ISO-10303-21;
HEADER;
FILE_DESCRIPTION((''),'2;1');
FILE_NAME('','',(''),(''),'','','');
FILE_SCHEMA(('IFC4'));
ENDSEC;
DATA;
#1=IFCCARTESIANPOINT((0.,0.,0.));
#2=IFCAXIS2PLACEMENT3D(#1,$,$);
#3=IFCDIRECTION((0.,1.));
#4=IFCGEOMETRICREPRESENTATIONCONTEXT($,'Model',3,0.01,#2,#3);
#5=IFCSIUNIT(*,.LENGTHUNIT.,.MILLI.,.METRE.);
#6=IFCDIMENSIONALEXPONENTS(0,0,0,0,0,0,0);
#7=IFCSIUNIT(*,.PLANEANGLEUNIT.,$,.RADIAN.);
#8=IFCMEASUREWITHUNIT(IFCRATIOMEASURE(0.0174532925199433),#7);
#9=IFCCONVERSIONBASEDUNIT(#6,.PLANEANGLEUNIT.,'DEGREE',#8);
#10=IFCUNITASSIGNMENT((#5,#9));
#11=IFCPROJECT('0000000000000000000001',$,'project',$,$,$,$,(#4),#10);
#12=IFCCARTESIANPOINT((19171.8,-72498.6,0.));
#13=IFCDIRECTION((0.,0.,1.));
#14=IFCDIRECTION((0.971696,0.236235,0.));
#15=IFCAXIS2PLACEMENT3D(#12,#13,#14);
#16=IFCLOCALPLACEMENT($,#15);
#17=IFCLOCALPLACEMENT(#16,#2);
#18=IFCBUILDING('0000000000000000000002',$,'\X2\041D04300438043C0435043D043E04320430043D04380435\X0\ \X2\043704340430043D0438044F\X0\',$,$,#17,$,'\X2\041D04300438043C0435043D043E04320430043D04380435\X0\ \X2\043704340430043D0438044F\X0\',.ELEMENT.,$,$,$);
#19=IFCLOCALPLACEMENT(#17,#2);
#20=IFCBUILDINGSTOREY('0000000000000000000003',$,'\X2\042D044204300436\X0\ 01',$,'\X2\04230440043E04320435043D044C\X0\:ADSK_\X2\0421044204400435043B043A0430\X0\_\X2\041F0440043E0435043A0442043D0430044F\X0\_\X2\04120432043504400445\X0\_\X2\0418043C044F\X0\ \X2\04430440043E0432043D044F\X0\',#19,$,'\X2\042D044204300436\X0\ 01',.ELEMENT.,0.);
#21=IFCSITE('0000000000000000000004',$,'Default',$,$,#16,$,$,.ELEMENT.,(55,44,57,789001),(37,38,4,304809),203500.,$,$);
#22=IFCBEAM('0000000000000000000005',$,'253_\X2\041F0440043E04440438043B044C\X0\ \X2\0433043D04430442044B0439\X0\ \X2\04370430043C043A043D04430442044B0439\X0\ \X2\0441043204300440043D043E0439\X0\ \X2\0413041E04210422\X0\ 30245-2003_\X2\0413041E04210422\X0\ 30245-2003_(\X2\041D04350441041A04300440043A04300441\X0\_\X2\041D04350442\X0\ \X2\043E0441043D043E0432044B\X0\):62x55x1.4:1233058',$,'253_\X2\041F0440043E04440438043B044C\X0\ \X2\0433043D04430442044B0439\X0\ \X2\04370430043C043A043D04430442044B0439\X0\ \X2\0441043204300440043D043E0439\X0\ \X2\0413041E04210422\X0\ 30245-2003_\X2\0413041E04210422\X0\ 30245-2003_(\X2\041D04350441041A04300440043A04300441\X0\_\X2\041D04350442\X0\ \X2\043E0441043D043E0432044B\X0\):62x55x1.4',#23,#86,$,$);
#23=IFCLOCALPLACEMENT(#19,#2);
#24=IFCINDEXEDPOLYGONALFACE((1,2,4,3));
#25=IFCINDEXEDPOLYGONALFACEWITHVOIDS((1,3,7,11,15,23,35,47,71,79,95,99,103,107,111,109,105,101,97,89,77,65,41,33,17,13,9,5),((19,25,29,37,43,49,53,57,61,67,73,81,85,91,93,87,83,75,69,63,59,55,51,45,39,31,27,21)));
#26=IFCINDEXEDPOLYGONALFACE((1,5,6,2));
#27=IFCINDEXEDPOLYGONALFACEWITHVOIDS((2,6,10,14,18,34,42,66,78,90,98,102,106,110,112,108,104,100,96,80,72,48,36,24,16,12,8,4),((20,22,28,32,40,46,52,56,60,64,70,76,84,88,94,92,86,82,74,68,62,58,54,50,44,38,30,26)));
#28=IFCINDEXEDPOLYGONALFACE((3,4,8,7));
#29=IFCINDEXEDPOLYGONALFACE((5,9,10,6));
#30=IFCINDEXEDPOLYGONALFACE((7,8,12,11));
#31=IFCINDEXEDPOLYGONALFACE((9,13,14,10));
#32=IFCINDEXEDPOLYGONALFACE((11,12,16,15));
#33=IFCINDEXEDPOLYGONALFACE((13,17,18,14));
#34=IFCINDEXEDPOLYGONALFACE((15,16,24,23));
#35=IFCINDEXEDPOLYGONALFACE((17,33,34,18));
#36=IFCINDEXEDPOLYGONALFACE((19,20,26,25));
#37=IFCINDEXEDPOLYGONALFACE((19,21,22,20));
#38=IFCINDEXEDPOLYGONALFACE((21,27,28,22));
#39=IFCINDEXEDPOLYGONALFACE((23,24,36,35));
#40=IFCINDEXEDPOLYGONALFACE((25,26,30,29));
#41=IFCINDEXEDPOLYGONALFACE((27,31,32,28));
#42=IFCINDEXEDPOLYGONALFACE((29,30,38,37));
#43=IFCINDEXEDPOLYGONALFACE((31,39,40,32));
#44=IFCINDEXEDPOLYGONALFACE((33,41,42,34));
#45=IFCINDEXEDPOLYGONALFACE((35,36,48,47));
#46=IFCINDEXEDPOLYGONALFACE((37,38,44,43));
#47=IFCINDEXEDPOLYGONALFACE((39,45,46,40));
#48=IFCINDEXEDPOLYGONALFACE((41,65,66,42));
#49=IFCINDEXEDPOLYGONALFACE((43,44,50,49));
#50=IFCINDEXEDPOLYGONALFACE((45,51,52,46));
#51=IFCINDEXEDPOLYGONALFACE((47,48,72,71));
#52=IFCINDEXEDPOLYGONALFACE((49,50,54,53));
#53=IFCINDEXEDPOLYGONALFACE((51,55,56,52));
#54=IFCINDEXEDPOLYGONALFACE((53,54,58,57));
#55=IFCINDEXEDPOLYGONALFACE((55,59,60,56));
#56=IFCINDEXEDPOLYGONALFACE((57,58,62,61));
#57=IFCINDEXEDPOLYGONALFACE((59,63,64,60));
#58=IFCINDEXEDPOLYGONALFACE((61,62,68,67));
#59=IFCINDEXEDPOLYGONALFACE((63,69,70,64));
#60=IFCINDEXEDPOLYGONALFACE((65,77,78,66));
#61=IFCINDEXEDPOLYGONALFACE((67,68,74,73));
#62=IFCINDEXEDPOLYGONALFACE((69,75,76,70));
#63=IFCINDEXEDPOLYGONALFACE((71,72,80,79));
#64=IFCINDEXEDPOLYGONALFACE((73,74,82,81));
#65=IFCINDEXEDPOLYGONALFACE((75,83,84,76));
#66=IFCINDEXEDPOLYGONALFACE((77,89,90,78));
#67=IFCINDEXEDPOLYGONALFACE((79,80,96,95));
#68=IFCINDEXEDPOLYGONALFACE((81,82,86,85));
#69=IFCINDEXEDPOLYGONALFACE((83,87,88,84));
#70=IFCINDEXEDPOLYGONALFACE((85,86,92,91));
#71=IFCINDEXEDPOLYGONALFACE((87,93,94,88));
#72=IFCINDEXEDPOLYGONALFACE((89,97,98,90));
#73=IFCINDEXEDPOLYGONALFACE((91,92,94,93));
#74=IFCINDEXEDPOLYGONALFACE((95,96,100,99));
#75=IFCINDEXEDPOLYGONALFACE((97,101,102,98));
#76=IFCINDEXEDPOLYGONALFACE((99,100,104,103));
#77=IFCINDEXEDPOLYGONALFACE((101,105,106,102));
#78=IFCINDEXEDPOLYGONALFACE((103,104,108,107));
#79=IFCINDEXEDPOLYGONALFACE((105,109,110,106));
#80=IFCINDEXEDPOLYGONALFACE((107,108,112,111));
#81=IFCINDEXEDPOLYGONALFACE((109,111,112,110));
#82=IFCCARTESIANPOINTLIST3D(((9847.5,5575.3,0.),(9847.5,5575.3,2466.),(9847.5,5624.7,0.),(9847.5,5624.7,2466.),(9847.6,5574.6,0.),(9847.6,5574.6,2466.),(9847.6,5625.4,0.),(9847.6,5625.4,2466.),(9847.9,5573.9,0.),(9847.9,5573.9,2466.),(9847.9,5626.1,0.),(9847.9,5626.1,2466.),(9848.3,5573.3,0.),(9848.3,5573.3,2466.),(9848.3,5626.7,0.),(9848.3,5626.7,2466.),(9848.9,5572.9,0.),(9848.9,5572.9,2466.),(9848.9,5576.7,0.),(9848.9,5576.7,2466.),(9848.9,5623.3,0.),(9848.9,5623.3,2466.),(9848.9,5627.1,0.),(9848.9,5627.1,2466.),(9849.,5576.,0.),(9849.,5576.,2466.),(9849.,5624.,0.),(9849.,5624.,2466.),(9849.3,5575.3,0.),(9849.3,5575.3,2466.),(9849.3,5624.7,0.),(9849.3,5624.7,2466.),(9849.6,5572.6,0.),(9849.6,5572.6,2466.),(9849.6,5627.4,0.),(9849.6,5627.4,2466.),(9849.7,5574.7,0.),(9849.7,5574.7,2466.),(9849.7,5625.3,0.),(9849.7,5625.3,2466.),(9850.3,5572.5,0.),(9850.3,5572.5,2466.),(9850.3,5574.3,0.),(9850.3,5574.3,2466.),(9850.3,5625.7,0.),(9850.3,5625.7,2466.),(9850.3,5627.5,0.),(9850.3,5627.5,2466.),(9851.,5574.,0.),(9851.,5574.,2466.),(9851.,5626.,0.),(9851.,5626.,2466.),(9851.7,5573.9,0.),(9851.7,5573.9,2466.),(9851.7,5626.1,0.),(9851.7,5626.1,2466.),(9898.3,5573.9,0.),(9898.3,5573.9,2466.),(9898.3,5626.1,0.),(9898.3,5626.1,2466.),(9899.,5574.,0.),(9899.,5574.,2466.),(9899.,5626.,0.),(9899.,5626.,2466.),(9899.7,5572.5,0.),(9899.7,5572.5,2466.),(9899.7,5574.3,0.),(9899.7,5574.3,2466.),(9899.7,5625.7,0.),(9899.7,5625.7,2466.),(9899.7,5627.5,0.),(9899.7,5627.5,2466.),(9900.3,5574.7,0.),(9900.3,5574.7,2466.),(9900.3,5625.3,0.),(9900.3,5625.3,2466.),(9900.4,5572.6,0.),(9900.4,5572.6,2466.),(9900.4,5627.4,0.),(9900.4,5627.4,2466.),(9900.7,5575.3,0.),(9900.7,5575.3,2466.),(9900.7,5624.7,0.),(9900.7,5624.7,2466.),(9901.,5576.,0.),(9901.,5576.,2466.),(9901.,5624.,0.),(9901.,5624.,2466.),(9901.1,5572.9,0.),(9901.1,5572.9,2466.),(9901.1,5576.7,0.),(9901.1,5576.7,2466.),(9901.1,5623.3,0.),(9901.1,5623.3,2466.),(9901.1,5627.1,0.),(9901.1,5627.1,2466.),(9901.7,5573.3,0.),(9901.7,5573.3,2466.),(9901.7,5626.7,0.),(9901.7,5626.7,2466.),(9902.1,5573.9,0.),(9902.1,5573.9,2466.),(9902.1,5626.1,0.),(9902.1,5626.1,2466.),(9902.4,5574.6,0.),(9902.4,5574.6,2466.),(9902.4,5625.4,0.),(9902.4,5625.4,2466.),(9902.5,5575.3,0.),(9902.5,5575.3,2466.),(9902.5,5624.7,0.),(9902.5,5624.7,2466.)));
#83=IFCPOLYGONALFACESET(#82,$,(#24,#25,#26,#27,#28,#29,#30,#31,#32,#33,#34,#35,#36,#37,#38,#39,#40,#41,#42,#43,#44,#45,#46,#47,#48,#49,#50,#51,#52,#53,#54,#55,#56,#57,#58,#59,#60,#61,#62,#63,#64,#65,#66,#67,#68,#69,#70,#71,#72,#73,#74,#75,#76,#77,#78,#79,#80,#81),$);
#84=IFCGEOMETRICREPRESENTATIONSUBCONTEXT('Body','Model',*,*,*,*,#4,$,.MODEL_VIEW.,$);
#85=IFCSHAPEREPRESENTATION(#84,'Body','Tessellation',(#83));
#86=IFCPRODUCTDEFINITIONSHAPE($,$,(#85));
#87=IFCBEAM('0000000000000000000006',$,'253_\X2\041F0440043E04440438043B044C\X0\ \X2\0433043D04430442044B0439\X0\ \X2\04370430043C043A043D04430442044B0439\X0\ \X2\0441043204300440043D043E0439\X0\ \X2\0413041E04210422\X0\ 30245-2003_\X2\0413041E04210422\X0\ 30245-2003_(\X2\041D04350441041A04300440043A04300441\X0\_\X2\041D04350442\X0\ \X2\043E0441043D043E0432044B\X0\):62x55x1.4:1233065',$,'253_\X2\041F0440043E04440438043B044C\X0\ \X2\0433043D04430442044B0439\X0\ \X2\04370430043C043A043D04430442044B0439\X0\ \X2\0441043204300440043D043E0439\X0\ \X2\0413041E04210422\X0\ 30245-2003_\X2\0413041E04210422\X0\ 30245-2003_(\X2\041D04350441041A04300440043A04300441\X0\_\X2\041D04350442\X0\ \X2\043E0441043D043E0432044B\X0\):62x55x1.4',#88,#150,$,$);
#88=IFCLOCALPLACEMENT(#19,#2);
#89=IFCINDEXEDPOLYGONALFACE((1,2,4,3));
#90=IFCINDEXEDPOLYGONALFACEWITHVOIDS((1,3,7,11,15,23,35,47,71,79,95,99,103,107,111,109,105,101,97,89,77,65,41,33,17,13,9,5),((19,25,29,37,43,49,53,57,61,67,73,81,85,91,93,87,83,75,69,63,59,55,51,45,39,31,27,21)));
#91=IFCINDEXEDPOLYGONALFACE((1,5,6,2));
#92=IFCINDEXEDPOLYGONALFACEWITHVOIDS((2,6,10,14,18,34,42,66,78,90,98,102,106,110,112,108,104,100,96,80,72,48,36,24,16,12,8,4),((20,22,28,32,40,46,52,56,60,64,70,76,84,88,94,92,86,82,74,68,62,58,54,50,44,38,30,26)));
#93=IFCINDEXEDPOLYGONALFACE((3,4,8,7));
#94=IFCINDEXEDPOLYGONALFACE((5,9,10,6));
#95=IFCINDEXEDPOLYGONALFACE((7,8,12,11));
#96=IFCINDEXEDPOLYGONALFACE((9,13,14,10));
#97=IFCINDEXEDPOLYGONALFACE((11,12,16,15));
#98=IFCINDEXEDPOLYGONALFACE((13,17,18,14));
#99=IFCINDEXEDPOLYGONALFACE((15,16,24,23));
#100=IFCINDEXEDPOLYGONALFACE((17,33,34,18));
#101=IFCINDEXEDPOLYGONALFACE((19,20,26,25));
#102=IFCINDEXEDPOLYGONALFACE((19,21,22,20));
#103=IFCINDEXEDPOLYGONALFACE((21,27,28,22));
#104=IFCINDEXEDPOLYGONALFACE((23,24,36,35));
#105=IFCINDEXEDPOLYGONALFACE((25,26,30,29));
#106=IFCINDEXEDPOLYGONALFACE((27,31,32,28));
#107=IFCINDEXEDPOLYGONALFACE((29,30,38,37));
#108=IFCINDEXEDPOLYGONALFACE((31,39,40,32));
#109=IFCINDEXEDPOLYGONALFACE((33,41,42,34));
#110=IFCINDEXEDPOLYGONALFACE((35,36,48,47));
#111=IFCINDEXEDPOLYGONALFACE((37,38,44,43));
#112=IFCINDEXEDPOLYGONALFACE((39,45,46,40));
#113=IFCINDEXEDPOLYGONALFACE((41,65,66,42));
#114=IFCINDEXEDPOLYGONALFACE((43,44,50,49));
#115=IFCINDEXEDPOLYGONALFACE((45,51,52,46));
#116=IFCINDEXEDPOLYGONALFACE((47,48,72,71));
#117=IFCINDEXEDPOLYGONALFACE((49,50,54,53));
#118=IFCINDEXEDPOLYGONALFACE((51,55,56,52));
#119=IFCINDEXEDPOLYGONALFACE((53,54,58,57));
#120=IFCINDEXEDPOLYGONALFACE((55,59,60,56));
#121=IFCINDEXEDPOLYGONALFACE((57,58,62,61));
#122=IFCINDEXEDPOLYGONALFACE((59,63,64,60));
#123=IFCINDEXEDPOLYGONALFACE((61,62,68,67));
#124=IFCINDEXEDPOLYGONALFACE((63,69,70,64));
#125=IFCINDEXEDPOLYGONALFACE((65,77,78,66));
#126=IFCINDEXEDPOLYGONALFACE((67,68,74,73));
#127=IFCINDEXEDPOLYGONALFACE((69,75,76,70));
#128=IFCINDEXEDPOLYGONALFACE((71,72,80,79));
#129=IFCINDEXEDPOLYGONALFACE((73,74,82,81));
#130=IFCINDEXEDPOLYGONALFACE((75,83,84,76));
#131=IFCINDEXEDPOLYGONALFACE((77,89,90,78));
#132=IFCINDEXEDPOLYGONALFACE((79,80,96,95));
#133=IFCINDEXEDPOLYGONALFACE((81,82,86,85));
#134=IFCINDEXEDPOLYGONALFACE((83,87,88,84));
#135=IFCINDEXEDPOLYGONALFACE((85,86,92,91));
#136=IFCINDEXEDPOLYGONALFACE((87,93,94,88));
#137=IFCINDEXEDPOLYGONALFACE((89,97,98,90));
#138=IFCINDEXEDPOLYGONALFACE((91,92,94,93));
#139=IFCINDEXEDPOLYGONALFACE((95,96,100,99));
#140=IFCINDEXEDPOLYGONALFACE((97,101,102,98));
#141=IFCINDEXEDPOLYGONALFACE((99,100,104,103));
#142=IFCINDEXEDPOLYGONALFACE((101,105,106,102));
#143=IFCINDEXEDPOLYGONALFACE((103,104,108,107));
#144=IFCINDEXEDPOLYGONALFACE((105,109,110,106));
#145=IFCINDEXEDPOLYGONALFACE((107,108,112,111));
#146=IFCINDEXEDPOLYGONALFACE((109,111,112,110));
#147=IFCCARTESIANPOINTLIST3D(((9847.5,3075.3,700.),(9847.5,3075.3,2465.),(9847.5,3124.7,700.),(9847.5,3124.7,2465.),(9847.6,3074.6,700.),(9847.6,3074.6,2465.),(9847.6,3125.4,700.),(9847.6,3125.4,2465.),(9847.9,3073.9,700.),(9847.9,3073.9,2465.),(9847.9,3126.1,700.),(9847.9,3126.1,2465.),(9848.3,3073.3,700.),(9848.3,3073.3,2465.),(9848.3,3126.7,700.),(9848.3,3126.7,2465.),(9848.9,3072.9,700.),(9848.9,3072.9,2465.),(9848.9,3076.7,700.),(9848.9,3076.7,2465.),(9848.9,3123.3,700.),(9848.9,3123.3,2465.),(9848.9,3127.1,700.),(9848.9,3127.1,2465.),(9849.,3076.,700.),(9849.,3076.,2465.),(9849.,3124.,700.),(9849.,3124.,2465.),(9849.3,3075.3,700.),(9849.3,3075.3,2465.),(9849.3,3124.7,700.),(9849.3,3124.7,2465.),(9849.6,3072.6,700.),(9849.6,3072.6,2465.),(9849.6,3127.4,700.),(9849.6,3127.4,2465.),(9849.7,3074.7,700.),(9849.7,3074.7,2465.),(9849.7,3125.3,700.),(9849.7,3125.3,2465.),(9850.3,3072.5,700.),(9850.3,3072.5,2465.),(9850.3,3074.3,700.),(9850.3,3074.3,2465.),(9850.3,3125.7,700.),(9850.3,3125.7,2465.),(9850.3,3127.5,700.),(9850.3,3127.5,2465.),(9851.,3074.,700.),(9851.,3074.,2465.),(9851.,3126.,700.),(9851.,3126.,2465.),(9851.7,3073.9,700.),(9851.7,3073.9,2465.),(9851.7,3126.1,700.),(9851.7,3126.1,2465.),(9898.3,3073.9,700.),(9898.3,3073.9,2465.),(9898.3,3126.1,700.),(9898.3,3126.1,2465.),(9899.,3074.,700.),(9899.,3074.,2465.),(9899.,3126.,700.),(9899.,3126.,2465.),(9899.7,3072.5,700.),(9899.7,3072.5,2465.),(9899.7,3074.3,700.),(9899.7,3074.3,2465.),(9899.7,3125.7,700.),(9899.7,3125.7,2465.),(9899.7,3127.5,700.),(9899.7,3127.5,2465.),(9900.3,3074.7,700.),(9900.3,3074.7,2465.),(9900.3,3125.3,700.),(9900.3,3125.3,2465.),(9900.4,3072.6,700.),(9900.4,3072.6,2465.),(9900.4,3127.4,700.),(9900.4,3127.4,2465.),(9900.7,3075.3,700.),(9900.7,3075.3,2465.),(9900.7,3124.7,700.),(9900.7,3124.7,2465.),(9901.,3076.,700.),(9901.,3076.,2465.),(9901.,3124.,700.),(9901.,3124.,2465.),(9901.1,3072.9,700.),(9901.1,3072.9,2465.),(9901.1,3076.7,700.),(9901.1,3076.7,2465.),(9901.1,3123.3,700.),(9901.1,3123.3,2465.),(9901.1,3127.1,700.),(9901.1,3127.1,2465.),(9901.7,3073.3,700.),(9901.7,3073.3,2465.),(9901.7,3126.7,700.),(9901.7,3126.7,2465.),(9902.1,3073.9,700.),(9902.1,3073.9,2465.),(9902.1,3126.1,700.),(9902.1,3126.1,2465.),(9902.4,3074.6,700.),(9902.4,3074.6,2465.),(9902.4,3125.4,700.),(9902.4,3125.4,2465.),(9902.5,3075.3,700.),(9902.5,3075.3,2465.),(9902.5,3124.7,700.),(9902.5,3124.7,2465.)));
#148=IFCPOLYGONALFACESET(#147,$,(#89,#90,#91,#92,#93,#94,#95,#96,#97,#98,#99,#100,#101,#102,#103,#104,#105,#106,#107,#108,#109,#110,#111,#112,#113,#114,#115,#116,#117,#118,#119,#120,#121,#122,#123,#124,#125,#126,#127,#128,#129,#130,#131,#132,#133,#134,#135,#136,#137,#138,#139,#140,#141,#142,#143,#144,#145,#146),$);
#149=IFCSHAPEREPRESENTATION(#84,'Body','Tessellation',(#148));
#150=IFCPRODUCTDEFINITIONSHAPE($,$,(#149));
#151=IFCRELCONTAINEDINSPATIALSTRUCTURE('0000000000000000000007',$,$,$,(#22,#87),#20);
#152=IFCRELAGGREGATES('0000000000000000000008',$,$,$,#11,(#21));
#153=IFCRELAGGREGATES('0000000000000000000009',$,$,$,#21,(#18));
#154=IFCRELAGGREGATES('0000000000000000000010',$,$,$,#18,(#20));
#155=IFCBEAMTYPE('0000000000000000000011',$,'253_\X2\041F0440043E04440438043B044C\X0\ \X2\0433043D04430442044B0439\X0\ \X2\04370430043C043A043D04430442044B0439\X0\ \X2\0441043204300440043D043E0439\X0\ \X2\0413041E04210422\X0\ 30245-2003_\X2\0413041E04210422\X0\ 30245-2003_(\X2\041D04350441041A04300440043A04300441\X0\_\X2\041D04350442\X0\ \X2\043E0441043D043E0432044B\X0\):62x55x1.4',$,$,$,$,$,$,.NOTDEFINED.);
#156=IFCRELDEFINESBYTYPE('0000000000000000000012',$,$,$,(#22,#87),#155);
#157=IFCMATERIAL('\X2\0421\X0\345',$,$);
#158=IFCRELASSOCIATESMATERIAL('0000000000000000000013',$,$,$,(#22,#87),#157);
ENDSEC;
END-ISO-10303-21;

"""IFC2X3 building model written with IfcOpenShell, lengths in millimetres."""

from ifc_helpers import new_model, entity, si_unit, converted_unit, direction, frame, frame_2d, origin, place, context, subcontext, project, spatial, polyline, circle_curve, parameter, trimmed, segment, composite_curve, outline, extrude, material, type_object, element, save


model = new_model("IFC2X3")

# Units and contexts
model_context = context("Model", 3, precision=0.01, world=origin(), true_north=direction((0.0, 1.0)))
body_context = subcontext(model_context, "Body", "Model", "MODEL_VIEW")
ifc_project = project(units=[si_unit("LENGTHUNIT", "METRE", prefix="MILLI"), converted_unit("PLANEANGLEUNIT", "DEGREE", entity("IfcRatioMeasure", 0.0174532925199433), si_unit("PLANEANGLEUNIT", "RADIAN"), dimensions=[0, 0, 0, 0, 0, 0, 0])], contexts=[model_context])

# Site, building, storey
site_placement = place(None, frame((19171.8, -72498.6, 0.0), z_axis=(0.0, 0.0, 1.0), x_axis=(0.971696, 0.236235, 0.0)))
site = spatial("IfcSite", under=ifc_project, at=site_placement, Name="Default", CompositionType="ELEMENT", RefLatitude=(55, 44, 57, 789001), RefLongitude=(37, 38, 4, 304809), RefElevation=203500.0)
building_placement = place(site_placement, origin())
building = spatial("IfcBuilding", under=site, at=building_placement, Name="Наименование здания", LongName="Наименование здания", CompositionType="ELEMENT")
storey_placement = place(building_placement, origin())
storey = spatial("IfcBuildingStorey", under=building, at=storey_placement, Name="Этаж 01", ObjectType="Уровень:ADSK_Стрелка_Проектная_Вверх_Имя уровня", LongName="Этаж 01", CompositionType="ELEMENT", Elevation=0.0)

# Beams
ifc_material_1 = material(Name="С345")
beam_type_1 = type_object("IfcBeamType", Name="253_Профиль гнутый замкнутый сварной ГОСТ 30245-2003_ГОСТ 30245-2003_(НесКаркас_Нет основы):62x55x1.4", PredefinedType="NOTDEFINED")
beam_1_placement = place(storey_placement, frame((9845.9, 5570.9, 0.0), z_axis=(1.0, 0.0, 0.0), x_axis=(0.0, 0.0, -1.0)))
element("IfcBeam", 1, at=beam_1_placement, inside=storey, type_object=beam_type_1, material=ifc_material_1, Name="253_Профиль гнутый замкнутый сварной ГОСТ 30245-2003_ГОСТ 30245-2003_(НесКаркас_Нет основы):62x55x1.4:1233058", ObjectType="253_Профиль гнутый замкнутый сварной ГОСТ 30245-2003_ГОСТ 30245-2003_(НесКаркас_Нет основы):62x55x1.4", context=body_context, shape_type="SweptSolid", body=[
    extrude(outline(composite_curve([segment(trimmed(circle_curve(frame_2d((24.7, -24.7), x_axis=(1.0, 0.0)), 2.8), [parameter(270.0)], [parameter(0.0)], True, "PARAMETER"), True, "CONTINUOUS"), segment(polyline([(27.5, -24.7), (27.5, 24.7)]), True, "CONTINUOUS"), segment(trimmed(circle_curve(frame_2d((24.7, 24.7), x_axis=(1.0, 0.0)), 2.8), [parameter(0.0)], [parameter(90.0)], True, "PARAMETER"), True, "CONTINUOUS"), segment(polyline([(24.7, 27.5), (-24.7, 27.5)]), True, "CONTINUOUS"), segment(trimmed(circle_curve(frame_2d((-24.7, 24.7), x_axis=(1.0, 0.0)), 2.8), [parameter(90.0)], [parameter(180.0)], True, "PARAMETER"), True, "CONTINUOUS"), segment(polyline([(-27.5, 24.7), (-27.5, -24.7)]), True, "CONTINUOUS"), segment(trimmed(circle_curve(frame_2d((-24.7, -24.7), x_axis=(1.0, 0.0)), 2.8), [parameter(180.0)], [parameter(270.0)], True, "PARAMETER"), True, "CONTINUOUS"), segment(polyline([(-24.7, -27.5), (24.7, -27.5)]), True, "CONTINUOUS")], self_intersect=False), holes=[composite_curve([segment(polyline([(23.3, -26.1), (-23.3, -26.1)]), True, "CONTINUOUS"), segment(trimmed(circle_curve(frame_2d((-23.3, -23.3), x_axis=(1.0, 0.0)), 2.8), [parameter(180.0)], [parameter(270.0)], True, "PARAMETER"), False, "CONTINUOUS"), segment(polyline([(-26.1, -23.3), (-26.1, 23.3)]), True, "CONTINUOUS"), segment(trimmed(circle_curve(frame_2d((-23.3, 23.3), x_axis=(1.0, 0.0)), 2.8), [parameter(90.0)], [parameter(180.0)], True, "PARAMETER"), False, "CONTINUOUS"), segment(polyline([(-23.3, 26.1), (23.3, 26.1)]), True, "CONTINUOUS"), segment(trimmed(circle_curve(frame_2d((23.3, 23.3), x_axis=(1.0, 0.0)), 2.8), [parameter(0.0)], [parameter(90.0)], True, "PARAMETER"), False, "CONTINUOUS"), segment(polyline([(26.1, 23.3), (26.1, -23.3)]), True, "CONTINUOUS"), segment(trimmed(circle_curve(frame_2d((23.3, -23.3), x_axis=(1.0, 0.0)), 2.8), [parameter(270.0)], [parameter(0.0)], True, "PARAMETER"), False, "CONTINUOUS")], self_intersect=False)]), frame((-2466.0, 29.1, 29.1), z_axis=(1.0, 0.0, 0.0), x_axis=(0.0, 1.0, 0.0)), (0.0, 0.0, 1.0), 2466.0),
])
beam_2_placement = place(storey_placement, frame((9845.9, 3070.9, 700.0), z_axis=(1.0, 0.0, 0.0), x_axis=(0.0, 0.0, 1.0)))
element("IfcBeam", 2, at=beam_2_placement, inside=storey, type_object=beam_type_1, material=ifc_material_1, Name="253_Профиль гнутый замкнутый сварной ГОСТ 30245-2003_ГОСТ 30245-2003_(НесКаркас_Нет основы):62x55x1.4:1233065", ObjectType="253_Профиль гнутый замкнутый сварной ГОСТ 30245-2003_ГОСТ 30245-2003_(НесКаркас_Нет основы):62x55x1.4", context=body_context, shape_type="SweptSolid", body=[
    extrude(outline(composite_curve([segment(trimmed(circle_curve(frame_2d((24.7, -24.7), x_axis=(1.0, 0.0)), 2.8), [parameter(270.0)], [parameter(0.0)], True, "PARAMETER"), True, "CONTINUOUS"), segment(polyline([(27.5, -24.7), (27.5, 24.7)]), True, "CONTINUOUS"), segment(trimmed(circle_curve(frame_2d((24.7, 24.7), x_axis=(1.0, 0.0)), 2.8), [parameter(0.0)], [parameter(90.0)], True, "PARAMETER"), True, "CONTINUOUS"), segment(polyline([(24.7, 27.5), (-24.7, 27.5)]), True, "CONTINUOUS"), segment(trimmed(circle_curve(frame_2d((-24.7, 24.7), x_axis=(1.0, 0.0)), 2.8), [parameter(90.0)], [parameter(180.0)], True, "PARAMETER"), True, "CONTINUOUS"), segment(polyline([(-27.5, 24.7), (-27.5, -24.7)]), True, "CONTINUOUS"), segment(trimmed(circle_curve(frame_2d((-24.7, -24.7), x_axis=(1.0, 0.0)), 2.8), [parameter(180.0)], [parameter(270.0)], True, "PARAMETER"), True, "CONTINUOUS"), segment(polyline([(-24.7, -27.5), (24.7, -27.5)]), True, "CONTINUOUS")], self_intersect=False), holes=[composite_curve([segment(polyline([(23.3, -26.1), (-23.3, -26.1)]), True, "CONTINUOUS"), segment(trimmed(circle_curve(frame_2d((-23.3, -23.3), x_axis=(1.0, 0.0)), 2.8), [parameter(180.0)], [parameter(270.0)], True, "PARAMETER"), False, "CONTINUOUS"), segment(polyline([(-26.1, -23.3), (-26.1, 23.3)]), True, "CONTINUOUS"), segment(trimmed(circle_curve(frame_2d((-23.3, 23.3), x_axis=(1.0, 0.0)), 2.8), [parameter(90.0)], [parameter(180.0)], True, "PARAMETER"), False, "CONTINUOUS"), segment(polyline([(-23.3, 26.1), (23.3, 26.1)]), True, "CONTINUOUS"), segment(trimmed(circle_curve(frame_2d((23.3, 23.3), x_axis=(1.0, 0.0)), 2.8), [parameter(0.0)], [parameter(90.0)], True, "PARAMETER"), False, "CONTINUOUS"), segment(polyline([(26.1, 23.3), (26.1, -23.3)]), True, "CONTINUOUS"), segment(trimmed(circle_curve(frame_2d((23.3, -23.3), x_axis=(1.0, 0.0)), 2.8), [parameter(270.0)], [parameter(0.0)], True, "PARAMETER"), False, "CONTINUOUS")], self_intersect=False)]), frame((0.0, -29.1, 29.1), z_axis=(1.0, 0.0, 0.0), x_axis=(0.0, -1.0, 0.0)), (0.0, 0.0, 1.0), 1765.0),
])

save(model, "model.ifc")
